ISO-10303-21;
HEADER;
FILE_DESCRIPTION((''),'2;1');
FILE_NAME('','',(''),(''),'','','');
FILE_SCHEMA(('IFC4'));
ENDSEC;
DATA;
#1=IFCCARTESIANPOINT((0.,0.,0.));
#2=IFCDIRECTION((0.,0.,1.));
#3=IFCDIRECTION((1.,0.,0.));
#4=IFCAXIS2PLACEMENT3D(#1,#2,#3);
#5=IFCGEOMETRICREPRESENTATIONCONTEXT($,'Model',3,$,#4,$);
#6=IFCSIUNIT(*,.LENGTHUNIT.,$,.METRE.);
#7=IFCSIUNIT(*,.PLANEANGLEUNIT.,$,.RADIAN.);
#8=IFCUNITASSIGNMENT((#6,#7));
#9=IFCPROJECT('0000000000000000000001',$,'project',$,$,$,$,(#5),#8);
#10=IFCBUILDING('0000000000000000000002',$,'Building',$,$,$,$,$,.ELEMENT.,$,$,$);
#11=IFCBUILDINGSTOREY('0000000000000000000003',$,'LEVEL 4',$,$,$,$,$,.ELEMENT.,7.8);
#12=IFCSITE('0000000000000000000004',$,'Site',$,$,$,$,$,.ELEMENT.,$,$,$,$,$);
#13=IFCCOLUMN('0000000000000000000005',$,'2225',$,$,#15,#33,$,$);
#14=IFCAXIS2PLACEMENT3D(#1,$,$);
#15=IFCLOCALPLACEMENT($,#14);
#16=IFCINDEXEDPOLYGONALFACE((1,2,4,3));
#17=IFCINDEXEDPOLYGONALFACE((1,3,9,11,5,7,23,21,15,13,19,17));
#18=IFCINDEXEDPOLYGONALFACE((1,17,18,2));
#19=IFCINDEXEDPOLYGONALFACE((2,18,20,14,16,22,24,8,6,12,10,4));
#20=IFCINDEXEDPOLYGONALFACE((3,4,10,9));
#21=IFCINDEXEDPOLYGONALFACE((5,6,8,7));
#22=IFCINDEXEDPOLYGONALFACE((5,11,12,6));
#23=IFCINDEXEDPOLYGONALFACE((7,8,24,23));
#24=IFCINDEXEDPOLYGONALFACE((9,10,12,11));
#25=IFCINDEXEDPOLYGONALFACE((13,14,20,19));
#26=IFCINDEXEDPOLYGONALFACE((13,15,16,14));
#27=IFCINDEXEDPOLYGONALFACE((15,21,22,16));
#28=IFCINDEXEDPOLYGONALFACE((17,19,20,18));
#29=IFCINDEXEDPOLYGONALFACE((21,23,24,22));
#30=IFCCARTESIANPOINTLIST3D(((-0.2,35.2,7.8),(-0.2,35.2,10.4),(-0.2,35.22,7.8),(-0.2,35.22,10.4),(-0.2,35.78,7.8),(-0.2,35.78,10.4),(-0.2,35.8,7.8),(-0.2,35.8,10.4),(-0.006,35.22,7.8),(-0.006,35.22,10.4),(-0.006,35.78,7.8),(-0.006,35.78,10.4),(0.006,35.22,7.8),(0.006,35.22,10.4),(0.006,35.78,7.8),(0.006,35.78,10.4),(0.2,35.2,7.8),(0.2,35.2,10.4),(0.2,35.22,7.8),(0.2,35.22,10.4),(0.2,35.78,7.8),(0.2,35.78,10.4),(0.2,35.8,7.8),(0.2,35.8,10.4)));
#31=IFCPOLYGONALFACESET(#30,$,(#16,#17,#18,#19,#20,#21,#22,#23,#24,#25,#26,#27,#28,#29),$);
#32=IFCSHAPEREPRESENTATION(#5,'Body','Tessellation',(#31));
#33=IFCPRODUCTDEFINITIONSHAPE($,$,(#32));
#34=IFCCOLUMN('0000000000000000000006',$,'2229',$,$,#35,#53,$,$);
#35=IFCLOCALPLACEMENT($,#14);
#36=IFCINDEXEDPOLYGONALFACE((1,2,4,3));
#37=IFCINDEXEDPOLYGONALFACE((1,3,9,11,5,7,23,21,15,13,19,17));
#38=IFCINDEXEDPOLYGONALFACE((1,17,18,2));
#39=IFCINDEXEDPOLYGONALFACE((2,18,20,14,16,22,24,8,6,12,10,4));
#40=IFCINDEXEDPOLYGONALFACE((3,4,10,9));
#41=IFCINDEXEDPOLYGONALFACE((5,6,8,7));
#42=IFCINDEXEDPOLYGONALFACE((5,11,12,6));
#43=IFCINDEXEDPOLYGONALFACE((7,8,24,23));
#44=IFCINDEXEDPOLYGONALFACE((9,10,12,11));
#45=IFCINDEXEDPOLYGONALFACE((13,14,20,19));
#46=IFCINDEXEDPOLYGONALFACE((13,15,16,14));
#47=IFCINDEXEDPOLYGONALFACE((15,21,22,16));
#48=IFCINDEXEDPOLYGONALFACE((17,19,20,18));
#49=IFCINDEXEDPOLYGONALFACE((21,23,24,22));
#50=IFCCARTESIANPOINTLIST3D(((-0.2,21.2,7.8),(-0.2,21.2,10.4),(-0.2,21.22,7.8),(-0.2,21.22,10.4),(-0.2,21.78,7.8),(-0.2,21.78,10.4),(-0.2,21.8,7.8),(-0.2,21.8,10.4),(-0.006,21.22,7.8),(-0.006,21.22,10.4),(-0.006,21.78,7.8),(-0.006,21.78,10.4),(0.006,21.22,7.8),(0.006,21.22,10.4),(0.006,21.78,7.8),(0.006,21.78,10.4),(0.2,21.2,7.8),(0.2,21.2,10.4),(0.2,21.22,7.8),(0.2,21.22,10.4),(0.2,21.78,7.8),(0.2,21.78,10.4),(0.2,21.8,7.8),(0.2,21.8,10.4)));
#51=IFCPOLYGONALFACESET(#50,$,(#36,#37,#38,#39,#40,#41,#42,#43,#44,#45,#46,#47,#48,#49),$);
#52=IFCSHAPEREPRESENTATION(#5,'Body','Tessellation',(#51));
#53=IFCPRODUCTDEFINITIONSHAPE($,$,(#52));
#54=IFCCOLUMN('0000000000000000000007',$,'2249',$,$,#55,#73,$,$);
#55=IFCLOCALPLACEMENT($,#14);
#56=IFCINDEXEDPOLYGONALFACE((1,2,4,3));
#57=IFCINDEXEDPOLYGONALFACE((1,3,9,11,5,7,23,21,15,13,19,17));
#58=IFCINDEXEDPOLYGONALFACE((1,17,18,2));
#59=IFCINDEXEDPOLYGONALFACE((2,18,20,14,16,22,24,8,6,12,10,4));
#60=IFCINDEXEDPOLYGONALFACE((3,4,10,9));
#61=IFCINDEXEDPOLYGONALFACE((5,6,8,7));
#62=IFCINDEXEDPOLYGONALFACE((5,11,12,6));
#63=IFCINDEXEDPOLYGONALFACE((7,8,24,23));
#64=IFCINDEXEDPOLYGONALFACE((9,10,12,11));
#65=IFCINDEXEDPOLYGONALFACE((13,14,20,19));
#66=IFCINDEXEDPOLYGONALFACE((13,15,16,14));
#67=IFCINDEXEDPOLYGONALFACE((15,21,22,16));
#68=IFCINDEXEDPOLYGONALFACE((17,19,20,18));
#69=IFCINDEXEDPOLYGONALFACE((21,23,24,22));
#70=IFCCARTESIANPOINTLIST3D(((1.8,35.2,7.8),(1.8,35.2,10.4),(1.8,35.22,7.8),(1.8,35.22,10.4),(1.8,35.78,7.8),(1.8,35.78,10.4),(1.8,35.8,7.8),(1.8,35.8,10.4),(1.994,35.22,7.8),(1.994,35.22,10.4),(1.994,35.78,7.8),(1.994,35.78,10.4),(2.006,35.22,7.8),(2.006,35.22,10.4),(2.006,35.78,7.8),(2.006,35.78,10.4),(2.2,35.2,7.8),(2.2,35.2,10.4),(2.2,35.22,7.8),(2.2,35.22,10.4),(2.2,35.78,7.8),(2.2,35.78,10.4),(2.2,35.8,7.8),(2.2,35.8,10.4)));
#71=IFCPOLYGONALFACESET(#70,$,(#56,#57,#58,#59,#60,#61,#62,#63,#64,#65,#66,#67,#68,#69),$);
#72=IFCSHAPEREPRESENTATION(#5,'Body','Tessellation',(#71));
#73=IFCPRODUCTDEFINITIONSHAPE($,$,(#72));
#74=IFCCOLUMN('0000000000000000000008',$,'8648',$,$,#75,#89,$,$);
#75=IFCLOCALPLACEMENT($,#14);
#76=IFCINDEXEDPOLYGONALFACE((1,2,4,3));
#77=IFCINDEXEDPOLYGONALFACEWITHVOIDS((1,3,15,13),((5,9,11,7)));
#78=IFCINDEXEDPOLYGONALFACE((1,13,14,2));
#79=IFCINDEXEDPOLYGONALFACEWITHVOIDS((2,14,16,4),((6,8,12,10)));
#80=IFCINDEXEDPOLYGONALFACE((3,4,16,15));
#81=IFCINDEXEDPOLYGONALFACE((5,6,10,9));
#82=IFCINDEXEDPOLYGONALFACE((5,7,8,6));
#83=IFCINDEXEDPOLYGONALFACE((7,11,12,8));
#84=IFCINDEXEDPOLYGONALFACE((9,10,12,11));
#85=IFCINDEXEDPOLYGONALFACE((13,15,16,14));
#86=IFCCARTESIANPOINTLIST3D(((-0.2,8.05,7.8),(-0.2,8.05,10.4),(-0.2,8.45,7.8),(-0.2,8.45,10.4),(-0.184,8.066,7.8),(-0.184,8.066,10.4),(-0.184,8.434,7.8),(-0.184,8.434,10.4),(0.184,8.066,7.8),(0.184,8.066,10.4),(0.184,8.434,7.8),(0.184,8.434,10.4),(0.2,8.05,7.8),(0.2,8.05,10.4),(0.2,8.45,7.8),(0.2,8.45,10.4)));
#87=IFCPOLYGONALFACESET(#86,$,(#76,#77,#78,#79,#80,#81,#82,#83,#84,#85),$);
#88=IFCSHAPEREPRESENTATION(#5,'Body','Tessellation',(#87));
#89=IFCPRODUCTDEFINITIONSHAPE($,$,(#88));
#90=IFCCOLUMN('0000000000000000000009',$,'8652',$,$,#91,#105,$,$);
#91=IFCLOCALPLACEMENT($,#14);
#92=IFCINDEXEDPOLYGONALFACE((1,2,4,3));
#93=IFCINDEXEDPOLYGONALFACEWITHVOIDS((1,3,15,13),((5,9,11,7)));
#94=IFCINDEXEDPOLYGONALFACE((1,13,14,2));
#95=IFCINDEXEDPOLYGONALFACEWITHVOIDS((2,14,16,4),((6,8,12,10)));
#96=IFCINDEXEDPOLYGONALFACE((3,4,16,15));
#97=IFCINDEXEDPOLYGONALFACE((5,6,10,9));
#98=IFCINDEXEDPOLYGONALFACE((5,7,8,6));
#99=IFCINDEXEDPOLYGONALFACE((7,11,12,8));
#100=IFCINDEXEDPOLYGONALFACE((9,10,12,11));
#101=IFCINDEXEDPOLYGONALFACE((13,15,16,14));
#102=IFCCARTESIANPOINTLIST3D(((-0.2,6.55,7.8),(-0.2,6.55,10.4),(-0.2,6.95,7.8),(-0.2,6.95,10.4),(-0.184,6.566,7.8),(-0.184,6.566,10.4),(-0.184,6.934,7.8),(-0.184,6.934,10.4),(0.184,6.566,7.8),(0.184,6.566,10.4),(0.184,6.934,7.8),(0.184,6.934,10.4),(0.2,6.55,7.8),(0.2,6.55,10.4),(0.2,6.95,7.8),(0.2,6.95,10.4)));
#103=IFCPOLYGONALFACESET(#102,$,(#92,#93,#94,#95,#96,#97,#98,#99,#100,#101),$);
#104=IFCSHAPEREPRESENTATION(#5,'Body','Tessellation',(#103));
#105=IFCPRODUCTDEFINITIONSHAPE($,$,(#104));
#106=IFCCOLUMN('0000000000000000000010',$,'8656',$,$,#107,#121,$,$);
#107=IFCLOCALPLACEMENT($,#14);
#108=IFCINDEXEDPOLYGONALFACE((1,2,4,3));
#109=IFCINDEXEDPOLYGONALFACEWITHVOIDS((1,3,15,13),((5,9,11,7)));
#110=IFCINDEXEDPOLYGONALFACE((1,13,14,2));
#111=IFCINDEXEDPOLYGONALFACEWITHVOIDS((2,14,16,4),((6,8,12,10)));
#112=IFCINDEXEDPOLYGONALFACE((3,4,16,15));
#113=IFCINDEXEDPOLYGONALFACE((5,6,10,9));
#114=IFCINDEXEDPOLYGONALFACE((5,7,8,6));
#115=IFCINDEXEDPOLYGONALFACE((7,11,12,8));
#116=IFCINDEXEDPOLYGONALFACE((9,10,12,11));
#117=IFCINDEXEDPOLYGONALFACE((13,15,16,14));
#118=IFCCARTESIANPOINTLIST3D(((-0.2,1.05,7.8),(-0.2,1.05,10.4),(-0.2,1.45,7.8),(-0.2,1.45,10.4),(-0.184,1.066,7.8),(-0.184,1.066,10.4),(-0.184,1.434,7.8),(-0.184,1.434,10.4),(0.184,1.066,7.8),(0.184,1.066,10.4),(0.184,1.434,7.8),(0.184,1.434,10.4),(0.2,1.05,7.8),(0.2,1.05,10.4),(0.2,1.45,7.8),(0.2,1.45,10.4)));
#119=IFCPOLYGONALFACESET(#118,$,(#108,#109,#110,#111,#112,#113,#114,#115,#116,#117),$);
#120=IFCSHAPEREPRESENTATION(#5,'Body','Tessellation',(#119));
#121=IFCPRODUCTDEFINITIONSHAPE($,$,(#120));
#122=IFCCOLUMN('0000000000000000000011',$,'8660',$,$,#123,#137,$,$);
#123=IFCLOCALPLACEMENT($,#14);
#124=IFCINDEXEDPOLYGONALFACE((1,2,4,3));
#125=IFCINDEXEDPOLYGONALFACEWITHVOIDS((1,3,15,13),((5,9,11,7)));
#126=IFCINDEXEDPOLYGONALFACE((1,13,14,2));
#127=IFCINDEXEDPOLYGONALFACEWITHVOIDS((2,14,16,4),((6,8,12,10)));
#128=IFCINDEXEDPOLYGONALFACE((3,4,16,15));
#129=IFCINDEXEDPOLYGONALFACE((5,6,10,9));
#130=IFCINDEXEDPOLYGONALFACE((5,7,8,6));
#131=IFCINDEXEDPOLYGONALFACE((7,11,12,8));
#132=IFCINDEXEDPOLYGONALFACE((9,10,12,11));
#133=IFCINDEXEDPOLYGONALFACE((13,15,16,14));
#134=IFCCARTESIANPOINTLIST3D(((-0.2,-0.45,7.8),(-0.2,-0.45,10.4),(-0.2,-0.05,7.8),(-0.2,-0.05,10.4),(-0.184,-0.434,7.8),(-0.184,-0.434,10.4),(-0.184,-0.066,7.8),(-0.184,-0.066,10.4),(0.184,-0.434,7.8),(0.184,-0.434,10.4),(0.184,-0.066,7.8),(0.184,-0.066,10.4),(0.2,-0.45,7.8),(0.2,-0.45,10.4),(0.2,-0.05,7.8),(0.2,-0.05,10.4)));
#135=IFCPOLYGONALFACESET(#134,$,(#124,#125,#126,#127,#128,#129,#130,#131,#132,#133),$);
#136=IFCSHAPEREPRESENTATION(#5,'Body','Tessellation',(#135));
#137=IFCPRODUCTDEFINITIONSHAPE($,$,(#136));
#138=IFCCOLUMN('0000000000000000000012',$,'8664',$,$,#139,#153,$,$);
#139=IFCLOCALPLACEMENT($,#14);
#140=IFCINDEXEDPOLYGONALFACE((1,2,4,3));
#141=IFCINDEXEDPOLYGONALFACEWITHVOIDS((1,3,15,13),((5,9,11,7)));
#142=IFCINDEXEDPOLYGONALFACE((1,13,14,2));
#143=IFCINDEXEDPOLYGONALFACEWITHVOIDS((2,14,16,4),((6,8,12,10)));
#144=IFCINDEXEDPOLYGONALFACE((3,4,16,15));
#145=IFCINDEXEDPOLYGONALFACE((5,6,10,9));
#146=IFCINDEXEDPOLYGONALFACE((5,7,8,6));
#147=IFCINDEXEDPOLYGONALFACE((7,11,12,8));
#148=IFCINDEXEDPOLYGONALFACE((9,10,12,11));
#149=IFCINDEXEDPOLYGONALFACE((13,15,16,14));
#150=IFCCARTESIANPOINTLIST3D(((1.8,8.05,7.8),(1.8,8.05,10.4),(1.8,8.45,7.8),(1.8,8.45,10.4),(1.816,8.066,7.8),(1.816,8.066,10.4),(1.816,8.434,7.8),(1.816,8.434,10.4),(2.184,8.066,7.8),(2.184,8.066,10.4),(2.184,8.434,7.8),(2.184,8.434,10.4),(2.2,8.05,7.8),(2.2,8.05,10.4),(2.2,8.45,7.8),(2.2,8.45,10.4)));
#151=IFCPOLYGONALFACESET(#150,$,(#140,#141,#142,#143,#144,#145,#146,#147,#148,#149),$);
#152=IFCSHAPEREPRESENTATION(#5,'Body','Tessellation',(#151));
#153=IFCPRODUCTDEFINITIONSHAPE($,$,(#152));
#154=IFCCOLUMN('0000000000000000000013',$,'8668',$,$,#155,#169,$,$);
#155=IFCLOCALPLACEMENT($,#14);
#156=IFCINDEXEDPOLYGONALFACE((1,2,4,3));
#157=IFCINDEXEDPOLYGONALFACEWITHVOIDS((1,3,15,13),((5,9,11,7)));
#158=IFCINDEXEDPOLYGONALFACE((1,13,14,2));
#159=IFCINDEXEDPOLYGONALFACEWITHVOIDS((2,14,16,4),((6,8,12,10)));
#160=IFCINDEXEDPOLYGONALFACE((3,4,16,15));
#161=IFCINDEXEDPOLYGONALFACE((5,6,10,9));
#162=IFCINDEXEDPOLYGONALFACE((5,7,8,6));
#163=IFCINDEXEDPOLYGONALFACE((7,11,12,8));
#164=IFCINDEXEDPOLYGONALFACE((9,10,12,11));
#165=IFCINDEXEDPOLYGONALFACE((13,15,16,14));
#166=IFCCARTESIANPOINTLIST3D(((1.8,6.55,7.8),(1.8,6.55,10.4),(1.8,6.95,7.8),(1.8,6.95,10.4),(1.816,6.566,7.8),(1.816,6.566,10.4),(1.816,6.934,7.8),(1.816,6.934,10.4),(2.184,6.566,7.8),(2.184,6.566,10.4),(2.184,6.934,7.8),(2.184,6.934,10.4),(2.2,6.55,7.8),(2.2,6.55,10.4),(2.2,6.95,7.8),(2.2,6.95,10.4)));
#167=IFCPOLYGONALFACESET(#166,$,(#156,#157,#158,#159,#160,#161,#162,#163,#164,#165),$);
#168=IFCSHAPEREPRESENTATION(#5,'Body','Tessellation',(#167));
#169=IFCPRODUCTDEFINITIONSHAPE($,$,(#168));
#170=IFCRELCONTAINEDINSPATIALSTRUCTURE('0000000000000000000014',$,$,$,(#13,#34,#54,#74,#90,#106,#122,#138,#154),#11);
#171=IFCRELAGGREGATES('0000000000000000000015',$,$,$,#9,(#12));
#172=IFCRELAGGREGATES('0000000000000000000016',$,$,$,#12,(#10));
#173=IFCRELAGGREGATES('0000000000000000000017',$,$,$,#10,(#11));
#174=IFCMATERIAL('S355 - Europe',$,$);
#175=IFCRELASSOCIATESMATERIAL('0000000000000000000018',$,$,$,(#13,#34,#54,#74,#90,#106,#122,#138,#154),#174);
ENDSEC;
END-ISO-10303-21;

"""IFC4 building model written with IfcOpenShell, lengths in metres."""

from ifc_helpers import new_model, si_unit, frame, origin_with_axes, origin_2d_with_axis, place, context, project, spatial, hollow_rectangle, i_section, extrude, material, material_profile, profile_set, profile_usage, element, save


model = new_model("IFC4")

# Units and contexts
model_context = context("Model", 3, world=origin_with_axes())
ifc_project = project(units=[si_unit("LENGTHUNIT", "METRE"), si_unit("PLANEANGLEUNIT", "RADIAN")], contexts=[model_context])

# Site, building, storey
site = spatial("IfcSite", under=ifc_project, Name="Site", CompositionType="ELEMENT")
building = spatial("IfcBuilding", under=site, Name="Building", CompositionType="ELEMENT")
storey = spatial("IfcBuildingStorey", under=building, Name="LEVEL 4", CompositionType="ELEMENT", Elevation=7.8)

# Columns
ifc_material = material(Name="S355 - Europe")
ifc_material_profile_1 = material_profile(ifc_material, i_section(OverallWidth=0.4, OverallDepth=0.6, WebThickness=0.012, FlangeThickness=0.02, at=origin_2d_with_axis()))
ifc_profile_set_1 = profile_set([ifc_material_profile_1])
ifc_profile_usage_1 = profile_usage(ifc_profile_set_1, cardinal=10)
column_1_placement = place(None, frame((0.0, 35.5, 7.8), z_axis=(0.0, 0.0, 1.0), x_axis=(1.0, 0.0, 0.0)))
element("IfcColumn", 1, at=column_1_placement, inside=storey, material=ifc_profile_usage_1, Name="2225", context=model_context, shape_type="SweptSolid", body=[
    extrude(i_section(OverallWidth=0.4, OverallDepth=0.6, WebThickness=0.012, FlangeThickness=0.02, at=origin_2d_with_axis()), origin_with_axes(), (0.0, 0.0, 1.0), 2.6),
])
ifc_material_profile_2 = material_profile(ifc_material, i_section(OverallWidth=0.4, OverallDepth=0.6, WebThickness=0.012, FlangeThickness=0.02, at=origin_2d_with_axis()))
ifc_profile_set_2 = profile_set([ifc_material_profile_2])
ifc_profile_usage_2 = profile_usage(ifc_profile_set_2, cardinal=10)
column_2_placement = place(None, frame((0.0, 21.5, 7.8), z_axis=(0.0, 0.0, 1.0), x_axis=(1.0, 0.0, 0.0)))
element("IfcColumn", 2, at=column_2_placement, inside=storey, material=ifc_profile_usage_2, Name="2229", context=model_context, shape_type="SweptSolid", body=[
    extrude(i_section(OverallWidth=0.4, OverallDepth=0.6, WebThickness=0.012, FlangeThickness=0.02, at=origin_2d_with_axis()), origin_with_axes(), (0.0, 0.0, 1.0), 2.6),
])
ifc_material_profile_3 = material_profile(ifc_material, i_section(OverallWidth=0.4, OverallDepth=0.6, WebThickness=0.012, FlangeThickness=0.02, at=origin_2d_with_axis()))
ifc_profile_set_3 = profile_set([ifc_material_profile_3])
ifc_profile_usage_3 = profile_usage(ifc_profile_set_3, cardinal=10)
column_3_placement = place(None, frame((2.0, 35.5, 7.8), z_axis=(0.0, 0.0, 1.0), x_axis=(1.0, 0.0, 0.0)))
element("IfcColumn", 3, at=column_3_placement, inside=storey, material=ifc_profile_usage_3, Name="2249", context=model_context, shape_type="SweptSolid", body=[
    extrude(i_section(OverallWidth=0.4, OverallDepth=0.6, WebThickness=0.012, FlangeThickness=0.02, at=origin_2d_with_axis()), origin_with_axes(), (0.0, 0.0, 1.0), 2.6),
])
ifc_material_profile_4 = material_profile(ifc_material, hollow_rectangle(XDim=0.4, YDim=0.4, WallThickness=0.016, at=origin_2d_with_axis()))
ifc_profile_set_4 = profile_set([ifc_material_profile_4])
ifc_profile_usage_4 = profile_usage(ifc_profile_set_4, cardinal=10)
column_4_placement = place(None, frame((0.0, 8.25, 7.8), z_axis=(0.0, 0.0, 1.0), x_axis=(0.0, -1.0, 0.0)))
element("IfcColumn", 4, at=column_4_placement, inside=storey, material=ifc_profile_usage_4, Name="8648", context=model_context, shape_type="SweptSolid", body=[
    extrude(hollow_rectangle(XDim=0.4, YDim=0.4, WallThickness=0.016, at=origin_2d_with_axis()), origin_with_axes(), (0.0, 0.0, 1.0), 2.6),
])
ifc_material_profile_5 = material_profile(ifc_material, hollow_rectangle(XDim=0.4, YDim=0.4, WallThickness=0.016, at=origin_2d_with_axis()))
ifc_profile_set_5 = profile_set([ifc_material_profile_5])
ifc_profile_usage_5 = profile_usage(ifc_profile_set_5, cardinal=10)
column_5_placement = place(None, frame((0.0, 6.75, 7.8), z_axis=(0.0, 0.0, 1.0), x_axis=(0.0, -1.0, 0.0)))
element("IfcColumn", 5, at=column_5_placement, inside=storey, material=ifc_profile_usage_5, Name="8652", context=model_context, shape_type="SweptSolid", body=[
    extrude(hollow_rectangle(XDim=0.4, YDim=0.4, WallThickness=0.016, at=origin_2d_with_axis()), origin_with_axes(), (0.0, 0.0, 1.0), 2.6),
])
ifc_material_profile_6 = material_profile(ifc_material, hollow_rectangle(XDim=0.4, YDim=0.4, WallThickness=0.016, at=origin_2d_with_axis()))
ifc_profile_set_6 = profile_set([ifc_material_profile_6])
ifc_profile_usage_6 = profile_usage(ifc_profile_set_6, cardinal=10)
column_6_placement = place(None, frame((0.0, 1.25, 7.8), z_axis=(0.0, 0.0, 1.0), x_axis=(0.0, -1.0, 0.0)))
element("IfcColumn", 6, at=column_6_placement, inside=storey, material=ifc_profile_usage_6, Name="8656", context=model_context, shape_type="SweptSolid", body=[
    extrude(hollow_rectangle(XDim=0.4, YDim=0.4, WallThickness=0.016, at=origin_2d_with_axis()), origin_with_axes(), (0.0, 0.0, 1.0), 2.6),
])
ifc_material_profile_7 = material_profile(ifc_material, hollow_rectangle(XDim=0.4, YDim=0.4, WallThickness=0.016, at=origin_2d_with_axis()))
ifc_profile_set_7 = profile_set([ifc_material_profile_7])
ifc_profile_usage_7 = profile_usage(ifc_profile_set_7, cardinal=10)
column_7_placement = place(None, frame((0.0, -0.25, 7.8), z_axis=(0.0, 0.0, 1.0), x_axis=(0.0, -1.0, 0.0)))
element("IfcColumn", 7, at=column_7_placement, inside=storey, material=ifc_profile_usage_7, Name="8660", context=model_context, shape_type="SweptSolid", body=[
    extrude(hollow_rectangle(XDim=0.4, YDim=0.4, WallThickness=0.016, at=origin_2d_with_axis()), origin_with_axes(), (0.0, 0.0, 1.0), 2.6),
])
ifc_material_profile_8 = material_profile(ifc_material, hollow_rectangle(XDim=0.4, YDim=0.4, WallThickness=0.016, at=origin_2d_with_axis()))
ifc_profile_set_8 = profile_set([ifc_material_profile_8])
ifc_profile_usage_8 = profile_usage(ifc_profile_set_8, cardinal=10)
column_8_placement = place(None, frame((2.0, 8.25, 7.8), z_axis=(0.0, 0.0, 1.0), x_axis=(0.0, -1.0, 0.0)))
element("IfcColumn", 8, at=column_8_placement, inside=storey, material=ifc_profile_usage_8, Name="8664", context=model_context, shape_type="SweptSolid", body=[
    extrude(hollow_rectangle(XDim=0.4, YDim=0.4, WallThickness=0.016, at=origin_2d_with_axis()), origin_with_axes(), (0.0, 0.0, 1.0), 2.6),
])
ifc_material_profile_9 = material_profile(ifc_material, hollow_rectangle(XDim=0.4, YDim=0.4, WallThickness=0.016, at=origin_2d_with_axis()))
ifc_profile_set_9 = profile_set([ifc_material_profile_9])
ifc_profile_usage_9 = profile_usage(ifc_profile_set_9, cardinal=10)
column_9_placement = place(None, frame((2.0, 6.75, 7.8), z_axis=(0.0, 0.0, 1.0), x_axis=(0.0, -1.0, 0.0)))
element("IfcColumn", 9, at=column_9_placement, inside=storey, material=ifc_profile_usage_9, Name="8668", context=model_context, shape_type="SweptSolid", body=[
    extrude(hollow_rectangle(XDim=0.4, YDim=0.4, WallThickness=0.016, at=origin_2d_with_axis()), origin_with_axes(), (0.0, 0.0, 1.0), 2.6),
])

save(model, "model.ifc")
